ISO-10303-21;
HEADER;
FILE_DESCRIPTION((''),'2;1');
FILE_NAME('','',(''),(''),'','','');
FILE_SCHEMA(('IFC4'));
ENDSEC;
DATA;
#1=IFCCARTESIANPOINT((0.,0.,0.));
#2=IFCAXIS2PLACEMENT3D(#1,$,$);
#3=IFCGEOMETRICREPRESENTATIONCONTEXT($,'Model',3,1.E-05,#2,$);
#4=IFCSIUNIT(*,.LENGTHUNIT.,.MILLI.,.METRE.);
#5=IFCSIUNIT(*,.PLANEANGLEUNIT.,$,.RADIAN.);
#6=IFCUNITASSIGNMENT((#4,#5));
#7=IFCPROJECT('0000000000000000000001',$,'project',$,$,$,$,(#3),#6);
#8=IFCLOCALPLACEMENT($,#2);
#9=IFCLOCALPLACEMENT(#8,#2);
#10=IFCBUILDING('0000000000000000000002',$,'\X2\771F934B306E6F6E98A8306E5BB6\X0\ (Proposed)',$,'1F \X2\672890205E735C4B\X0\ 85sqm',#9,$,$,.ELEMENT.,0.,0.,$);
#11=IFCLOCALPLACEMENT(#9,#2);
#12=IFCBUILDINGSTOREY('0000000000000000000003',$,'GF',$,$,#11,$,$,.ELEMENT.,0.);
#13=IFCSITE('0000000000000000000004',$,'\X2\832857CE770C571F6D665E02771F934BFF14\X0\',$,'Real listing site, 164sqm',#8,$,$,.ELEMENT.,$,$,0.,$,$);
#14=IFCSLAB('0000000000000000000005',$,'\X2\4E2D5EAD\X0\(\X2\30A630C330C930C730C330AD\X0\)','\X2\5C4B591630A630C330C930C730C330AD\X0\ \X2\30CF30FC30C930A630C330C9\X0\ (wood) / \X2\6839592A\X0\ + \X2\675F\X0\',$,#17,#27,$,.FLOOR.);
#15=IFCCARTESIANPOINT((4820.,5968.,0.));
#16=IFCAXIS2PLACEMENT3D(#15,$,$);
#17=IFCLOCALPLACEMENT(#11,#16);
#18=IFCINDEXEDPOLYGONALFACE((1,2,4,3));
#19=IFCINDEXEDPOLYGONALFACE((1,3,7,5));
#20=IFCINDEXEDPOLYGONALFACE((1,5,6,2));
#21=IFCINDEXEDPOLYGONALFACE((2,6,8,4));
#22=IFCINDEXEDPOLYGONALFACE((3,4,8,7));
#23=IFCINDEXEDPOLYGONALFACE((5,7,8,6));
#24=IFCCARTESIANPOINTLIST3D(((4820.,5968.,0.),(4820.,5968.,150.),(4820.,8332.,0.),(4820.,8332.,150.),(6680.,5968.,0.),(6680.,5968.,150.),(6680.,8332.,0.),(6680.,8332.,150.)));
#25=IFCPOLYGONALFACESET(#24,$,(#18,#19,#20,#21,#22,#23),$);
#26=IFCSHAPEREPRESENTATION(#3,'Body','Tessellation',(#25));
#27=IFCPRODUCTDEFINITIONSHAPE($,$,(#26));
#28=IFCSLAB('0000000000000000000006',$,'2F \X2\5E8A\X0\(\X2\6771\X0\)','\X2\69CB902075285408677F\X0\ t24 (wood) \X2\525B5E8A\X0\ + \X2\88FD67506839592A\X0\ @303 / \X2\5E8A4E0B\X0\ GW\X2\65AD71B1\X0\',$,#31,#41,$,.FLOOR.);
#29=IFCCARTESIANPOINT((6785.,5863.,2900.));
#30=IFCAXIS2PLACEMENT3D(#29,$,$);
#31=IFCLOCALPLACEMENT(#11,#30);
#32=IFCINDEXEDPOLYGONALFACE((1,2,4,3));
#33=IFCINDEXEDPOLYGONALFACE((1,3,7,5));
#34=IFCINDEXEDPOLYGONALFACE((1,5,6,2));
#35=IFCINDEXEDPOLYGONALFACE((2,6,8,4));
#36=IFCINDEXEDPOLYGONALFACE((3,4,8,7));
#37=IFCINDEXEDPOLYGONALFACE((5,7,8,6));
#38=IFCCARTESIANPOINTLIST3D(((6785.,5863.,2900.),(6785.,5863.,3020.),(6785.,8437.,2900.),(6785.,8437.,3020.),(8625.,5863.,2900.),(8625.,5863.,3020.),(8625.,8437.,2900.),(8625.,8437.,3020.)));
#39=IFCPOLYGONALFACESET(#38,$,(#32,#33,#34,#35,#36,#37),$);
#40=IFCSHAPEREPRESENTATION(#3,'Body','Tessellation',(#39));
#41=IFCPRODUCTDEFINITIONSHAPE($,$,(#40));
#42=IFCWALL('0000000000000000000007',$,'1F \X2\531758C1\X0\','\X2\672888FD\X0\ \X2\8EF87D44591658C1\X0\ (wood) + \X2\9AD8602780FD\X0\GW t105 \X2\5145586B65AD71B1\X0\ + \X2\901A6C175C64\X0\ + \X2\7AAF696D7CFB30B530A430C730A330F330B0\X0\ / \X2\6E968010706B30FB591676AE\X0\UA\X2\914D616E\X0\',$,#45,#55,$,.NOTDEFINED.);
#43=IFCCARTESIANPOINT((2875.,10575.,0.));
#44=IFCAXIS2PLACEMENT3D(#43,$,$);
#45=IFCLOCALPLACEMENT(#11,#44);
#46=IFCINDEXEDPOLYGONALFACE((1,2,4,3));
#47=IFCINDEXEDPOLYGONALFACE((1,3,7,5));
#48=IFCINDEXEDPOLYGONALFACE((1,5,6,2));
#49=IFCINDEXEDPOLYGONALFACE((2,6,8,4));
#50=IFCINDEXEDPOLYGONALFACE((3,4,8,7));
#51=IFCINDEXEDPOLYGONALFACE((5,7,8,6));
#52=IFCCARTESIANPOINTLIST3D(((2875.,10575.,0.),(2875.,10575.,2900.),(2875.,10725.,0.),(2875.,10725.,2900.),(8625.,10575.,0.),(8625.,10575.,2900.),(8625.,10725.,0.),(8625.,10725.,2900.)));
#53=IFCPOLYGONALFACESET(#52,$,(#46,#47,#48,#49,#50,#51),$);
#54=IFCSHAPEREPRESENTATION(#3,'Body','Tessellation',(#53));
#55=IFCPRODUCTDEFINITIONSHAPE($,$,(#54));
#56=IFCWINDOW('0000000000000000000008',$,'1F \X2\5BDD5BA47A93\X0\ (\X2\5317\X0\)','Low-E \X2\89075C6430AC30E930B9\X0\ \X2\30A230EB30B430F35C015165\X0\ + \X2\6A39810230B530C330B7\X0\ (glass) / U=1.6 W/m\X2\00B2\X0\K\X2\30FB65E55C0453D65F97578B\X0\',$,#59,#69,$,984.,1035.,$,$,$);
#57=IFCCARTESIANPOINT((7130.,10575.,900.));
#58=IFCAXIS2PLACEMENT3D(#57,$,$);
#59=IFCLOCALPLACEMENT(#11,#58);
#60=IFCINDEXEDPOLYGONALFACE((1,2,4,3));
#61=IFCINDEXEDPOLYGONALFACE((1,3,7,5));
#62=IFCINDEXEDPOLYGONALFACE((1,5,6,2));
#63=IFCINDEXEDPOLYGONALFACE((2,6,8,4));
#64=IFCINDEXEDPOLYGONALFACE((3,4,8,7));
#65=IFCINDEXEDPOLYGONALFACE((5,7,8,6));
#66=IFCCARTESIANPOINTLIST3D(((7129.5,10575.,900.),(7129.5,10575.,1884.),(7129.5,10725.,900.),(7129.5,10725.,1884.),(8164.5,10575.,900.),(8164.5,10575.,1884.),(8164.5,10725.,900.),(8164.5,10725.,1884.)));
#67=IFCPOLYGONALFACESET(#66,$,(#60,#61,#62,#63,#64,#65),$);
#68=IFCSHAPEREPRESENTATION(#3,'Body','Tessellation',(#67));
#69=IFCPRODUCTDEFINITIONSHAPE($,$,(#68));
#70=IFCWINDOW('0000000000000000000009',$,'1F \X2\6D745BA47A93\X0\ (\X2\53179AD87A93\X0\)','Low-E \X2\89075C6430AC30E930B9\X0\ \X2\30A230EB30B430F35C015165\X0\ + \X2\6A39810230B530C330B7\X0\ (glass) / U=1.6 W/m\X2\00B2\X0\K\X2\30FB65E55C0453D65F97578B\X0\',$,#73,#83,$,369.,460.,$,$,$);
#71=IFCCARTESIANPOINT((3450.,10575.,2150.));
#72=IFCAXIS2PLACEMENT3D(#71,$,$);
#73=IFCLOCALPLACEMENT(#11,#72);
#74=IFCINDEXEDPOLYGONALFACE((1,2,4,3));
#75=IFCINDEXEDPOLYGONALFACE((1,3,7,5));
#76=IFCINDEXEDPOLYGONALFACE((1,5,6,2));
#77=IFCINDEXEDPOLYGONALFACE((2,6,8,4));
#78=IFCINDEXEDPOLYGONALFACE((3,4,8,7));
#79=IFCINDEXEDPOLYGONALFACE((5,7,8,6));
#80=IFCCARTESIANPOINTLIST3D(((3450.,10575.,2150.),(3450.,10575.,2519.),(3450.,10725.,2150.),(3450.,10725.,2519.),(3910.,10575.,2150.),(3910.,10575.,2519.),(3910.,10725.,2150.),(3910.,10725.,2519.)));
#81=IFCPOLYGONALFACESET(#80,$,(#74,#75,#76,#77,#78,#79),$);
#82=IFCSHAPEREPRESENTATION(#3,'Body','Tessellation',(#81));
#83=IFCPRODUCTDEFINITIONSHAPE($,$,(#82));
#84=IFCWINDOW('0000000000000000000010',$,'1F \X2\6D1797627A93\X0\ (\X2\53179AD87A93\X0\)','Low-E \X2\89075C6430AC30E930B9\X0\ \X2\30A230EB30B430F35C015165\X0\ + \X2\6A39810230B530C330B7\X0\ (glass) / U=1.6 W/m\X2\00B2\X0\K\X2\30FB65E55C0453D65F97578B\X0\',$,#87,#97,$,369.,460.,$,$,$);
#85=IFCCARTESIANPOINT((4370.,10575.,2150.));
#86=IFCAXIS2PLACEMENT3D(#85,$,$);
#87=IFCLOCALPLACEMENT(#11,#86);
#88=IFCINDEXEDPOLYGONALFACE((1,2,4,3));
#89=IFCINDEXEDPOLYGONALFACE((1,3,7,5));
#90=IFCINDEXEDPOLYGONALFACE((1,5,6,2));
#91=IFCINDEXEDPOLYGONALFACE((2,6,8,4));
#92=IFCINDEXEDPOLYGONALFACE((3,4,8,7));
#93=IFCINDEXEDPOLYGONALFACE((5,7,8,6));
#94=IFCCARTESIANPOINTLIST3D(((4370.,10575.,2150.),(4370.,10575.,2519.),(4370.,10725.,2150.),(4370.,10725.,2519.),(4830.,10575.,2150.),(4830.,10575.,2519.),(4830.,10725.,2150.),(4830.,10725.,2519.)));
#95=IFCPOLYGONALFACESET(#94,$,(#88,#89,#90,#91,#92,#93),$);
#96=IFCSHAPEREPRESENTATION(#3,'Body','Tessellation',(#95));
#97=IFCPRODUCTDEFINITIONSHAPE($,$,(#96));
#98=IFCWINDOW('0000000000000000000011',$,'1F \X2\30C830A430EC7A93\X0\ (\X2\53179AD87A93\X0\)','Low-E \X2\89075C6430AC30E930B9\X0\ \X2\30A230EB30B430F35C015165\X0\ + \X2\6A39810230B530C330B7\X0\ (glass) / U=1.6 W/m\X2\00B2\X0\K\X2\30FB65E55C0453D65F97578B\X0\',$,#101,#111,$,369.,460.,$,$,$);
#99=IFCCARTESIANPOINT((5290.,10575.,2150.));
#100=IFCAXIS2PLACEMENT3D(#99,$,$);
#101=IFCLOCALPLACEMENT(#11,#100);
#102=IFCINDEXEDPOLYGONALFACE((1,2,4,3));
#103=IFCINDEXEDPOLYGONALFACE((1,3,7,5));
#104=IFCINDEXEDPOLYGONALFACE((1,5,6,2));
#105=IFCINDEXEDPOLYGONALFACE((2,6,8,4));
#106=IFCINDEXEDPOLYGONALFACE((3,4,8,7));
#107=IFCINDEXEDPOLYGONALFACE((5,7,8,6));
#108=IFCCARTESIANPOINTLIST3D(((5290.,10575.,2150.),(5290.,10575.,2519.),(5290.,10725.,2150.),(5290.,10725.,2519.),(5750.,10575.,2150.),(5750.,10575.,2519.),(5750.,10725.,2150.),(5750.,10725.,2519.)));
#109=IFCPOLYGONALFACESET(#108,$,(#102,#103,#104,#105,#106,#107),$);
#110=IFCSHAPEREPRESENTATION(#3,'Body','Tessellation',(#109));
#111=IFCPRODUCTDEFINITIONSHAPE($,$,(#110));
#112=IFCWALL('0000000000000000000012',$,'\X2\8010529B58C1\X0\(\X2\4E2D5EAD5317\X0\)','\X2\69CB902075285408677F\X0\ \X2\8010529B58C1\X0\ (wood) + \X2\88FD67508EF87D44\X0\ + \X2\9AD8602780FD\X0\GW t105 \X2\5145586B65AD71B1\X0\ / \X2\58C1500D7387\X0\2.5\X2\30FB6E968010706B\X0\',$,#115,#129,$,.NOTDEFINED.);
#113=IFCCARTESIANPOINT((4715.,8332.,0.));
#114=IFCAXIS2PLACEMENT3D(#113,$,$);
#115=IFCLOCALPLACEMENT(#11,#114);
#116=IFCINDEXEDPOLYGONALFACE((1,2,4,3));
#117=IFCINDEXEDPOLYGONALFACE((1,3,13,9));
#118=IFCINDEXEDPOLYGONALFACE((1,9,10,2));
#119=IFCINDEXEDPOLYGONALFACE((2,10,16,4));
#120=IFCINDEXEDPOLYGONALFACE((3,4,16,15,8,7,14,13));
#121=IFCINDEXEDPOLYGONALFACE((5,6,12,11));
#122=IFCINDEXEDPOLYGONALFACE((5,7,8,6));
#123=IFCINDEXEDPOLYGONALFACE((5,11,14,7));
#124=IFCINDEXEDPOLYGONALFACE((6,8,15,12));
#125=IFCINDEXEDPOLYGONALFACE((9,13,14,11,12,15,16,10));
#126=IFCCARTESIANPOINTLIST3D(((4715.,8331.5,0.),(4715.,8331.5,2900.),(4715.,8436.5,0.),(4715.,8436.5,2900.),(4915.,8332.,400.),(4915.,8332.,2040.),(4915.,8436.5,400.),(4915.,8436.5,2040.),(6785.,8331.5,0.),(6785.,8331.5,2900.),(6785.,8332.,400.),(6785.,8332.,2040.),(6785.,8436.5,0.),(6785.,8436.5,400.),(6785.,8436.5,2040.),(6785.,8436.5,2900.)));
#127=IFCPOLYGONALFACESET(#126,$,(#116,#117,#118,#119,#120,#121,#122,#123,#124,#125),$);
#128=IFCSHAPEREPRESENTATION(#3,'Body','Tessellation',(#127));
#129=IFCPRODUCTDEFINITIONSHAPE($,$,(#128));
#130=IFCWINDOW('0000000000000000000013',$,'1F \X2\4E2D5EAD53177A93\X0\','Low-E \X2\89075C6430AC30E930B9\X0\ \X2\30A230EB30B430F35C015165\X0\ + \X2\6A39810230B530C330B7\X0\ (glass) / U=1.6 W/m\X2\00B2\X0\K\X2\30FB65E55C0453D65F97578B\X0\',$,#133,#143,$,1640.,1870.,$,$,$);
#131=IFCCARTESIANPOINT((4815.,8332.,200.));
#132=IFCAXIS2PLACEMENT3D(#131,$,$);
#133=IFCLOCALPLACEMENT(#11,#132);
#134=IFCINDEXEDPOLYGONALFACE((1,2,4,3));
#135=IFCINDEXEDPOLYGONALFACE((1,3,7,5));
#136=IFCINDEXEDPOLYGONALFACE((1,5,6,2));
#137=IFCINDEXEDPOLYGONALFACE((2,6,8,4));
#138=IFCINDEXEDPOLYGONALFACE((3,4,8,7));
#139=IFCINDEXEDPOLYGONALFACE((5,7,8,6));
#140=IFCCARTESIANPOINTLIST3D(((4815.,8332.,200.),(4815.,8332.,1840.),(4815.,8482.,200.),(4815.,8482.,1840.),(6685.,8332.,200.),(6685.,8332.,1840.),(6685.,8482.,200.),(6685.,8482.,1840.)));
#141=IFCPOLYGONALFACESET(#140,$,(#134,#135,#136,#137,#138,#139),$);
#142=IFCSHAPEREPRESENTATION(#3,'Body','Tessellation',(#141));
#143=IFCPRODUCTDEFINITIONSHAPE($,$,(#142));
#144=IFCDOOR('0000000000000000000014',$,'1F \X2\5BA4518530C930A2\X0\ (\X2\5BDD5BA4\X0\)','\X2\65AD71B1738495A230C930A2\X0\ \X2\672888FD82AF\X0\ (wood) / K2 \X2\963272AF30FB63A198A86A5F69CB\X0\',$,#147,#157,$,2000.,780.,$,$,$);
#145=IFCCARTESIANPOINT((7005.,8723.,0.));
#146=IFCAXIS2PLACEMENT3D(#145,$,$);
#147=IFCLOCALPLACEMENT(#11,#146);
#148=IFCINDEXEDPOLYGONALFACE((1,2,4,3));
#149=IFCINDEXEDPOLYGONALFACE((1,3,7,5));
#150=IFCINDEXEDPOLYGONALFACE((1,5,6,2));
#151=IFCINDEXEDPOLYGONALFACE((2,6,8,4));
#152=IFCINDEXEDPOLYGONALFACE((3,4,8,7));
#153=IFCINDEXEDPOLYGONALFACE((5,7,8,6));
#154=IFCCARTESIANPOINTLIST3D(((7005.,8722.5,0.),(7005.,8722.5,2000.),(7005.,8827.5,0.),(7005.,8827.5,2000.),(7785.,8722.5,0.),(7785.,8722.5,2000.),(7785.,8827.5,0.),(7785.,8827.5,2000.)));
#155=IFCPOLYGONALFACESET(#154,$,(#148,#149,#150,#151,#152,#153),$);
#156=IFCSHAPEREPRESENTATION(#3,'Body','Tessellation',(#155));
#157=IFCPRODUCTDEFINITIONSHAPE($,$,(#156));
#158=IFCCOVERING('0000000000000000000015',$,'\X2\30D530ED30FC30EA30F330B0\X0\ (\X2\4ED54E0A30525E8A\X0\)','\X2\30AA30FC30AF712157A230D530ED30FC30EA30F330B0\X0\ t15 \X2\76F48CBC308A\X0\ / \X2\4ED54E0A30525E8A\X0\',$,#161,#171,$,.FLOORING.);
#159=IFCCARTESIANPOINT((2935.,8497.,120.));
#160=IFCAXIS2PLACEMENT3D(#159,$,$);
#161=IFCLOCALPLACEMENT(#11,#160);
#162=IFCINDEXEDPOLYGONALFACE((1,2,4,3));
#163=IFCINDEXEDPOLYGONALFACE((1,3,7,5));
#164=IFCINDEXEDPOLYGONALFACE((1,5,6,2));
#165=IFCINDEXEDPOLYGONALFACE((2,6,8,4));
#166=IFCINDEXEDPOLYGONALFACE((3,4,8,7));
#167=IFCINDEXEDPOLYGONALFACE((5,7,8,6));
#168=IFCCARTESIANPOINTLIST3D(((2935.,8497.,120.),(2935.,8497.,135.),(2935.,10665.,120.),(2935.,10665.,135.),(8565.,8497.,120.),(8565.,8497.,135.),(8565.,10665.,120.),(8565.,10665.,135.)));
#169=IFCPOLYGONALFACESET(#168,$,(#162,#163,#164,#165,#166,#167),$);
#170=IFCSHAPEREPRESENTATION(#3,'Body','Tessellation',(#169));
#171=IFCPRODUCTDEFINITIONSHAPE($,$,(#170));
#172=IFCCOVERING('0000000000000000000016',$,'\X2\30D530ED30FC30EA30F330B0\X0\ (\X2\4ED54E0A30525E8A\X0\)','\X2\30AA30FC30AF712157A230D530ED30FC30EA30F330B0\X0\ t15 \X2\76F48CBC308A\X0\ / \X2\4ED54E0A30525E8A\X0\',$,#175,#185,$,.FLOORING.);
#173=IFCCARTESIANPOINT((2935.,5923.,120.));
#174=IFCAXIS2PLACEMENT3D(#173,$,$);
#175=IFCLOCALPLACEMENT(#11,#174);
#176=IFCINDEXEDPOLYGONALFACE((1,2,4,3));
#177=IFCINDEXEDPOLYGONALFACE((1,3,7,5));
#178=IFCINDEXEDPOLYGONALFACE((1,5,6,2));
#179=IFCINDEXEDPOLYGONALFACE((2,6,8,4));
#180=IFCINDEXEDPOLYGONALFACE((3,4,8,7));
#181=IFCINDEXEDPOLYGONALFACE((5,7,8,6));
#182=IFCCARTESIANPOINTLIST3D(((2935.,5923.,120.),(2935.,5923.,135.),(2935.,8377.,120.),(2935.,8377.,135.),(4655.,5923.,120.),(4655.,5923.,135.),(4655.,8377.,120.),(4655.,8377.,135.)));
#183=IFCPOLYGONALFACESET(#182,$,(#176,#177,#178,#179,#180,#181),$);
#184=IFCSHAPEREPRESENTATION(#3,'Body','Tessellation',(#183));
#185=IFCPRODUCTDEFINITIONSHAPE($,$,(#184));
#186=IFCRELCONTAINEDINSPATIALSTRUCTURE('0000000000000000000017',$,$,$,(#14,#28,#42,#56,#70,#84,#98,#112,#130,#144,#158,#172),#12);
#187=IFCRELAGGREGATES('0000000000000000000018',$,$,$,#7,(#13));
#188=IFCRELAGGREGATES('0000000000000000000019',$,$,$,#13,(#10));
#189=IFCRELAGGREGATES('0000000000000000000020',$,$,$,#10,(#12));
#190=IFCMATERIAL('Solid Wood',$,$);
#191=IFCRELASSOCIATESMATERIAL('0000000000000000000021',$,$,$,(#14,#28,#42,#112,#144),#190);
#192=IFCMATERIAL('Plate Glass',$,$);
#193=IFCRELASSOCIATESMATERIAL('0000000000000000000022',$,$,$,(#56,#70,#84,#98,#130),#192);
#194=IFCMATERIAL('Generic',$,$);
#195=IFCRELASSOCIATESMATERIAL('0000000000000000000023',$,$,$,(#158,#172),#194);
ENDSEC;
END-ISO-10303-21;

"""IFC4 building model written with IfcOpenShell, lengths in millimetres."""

from ifc_helpers import new_model, si_unit, frame, frame_2d, origin, place, context, project, spatial, rectangle, extrude, material, element, fill, save


model = new_model("IFC4")

# Units and contexts
model_context = context("Model", 3, precision=1e-05, world=origin())
ifc_project = project(units=[si_unit("LENGTHUNIT", "METRE", prefix="MILLI"), si_unit("PLANEANGLEUNIT", "RADIAN")], contexts=[model_context])

# Site, building, storey
site_placement = place(None, origin())
site = spatial("IfcSite", under=ifc_project, at=site_placement, Name="茨城県土浦市真鍋４", ObjectType="Real listing site, 164sqm", CompositionType="ELEMENT", RefElevation=0.0)
building_placement = place(site_placement, origin())
building = spatial("IfcBuilding", under=site, at=building_placement, Name="真鍋の潮風の家 (Proposed)", ObjectType="1F 木造平屋 85sqm", CompositionType="ELEMENT", ElevationOfRefHeight=0.0, ElevationOfTerrain=0.0)
storey_placement = place(building_placement, origin())
storey = spatial("IfcBuildingStorey", under=building, at=storey_placement, Name="GF", CompositionType="ELEMENT", Elevation=0.0)

# Slabs
ifc_material_1 = material(Name="Solid Wood")
slab_1_placement = place(storey_placement, frame((4820.0, 5968.0, 0.0)))
element("IfcSlab", 1, at=slab_1_placement, inside=storey, material=ifc_material_1, Name="中庭(ウッドデッキ)", Description="屋外ウッドデッキ ハードウッド (wood) / 根太 + 束", PredefinedType="FLOOR", context=model_context, shape_type="SweptSolid", body=[
    extrude(rectangle(XDim=1860.0, YDim=2364.0, at=frame_2d((930.0, 1182.0))), frame((4820.0, 5968.0, 0.0)), (0.0, 0.0, 1.0), 150.0),
])
slab_2_placement = place(storey_placement, frame((6785.0, 5863.0, 2900.0)))
element("IfcSlab", 2, at=slab_2_placement, inside=storey, material=ifc_material_1, Name="2F 床(東)", Description="構造用合板 t24 (wood) 剛床 + 製材根太 @303 / 床下 GW断熱", PredefinedType="FLOOR", context=model_context, shape_type="SweptSolid", body=[
    extrude(rectangle(XDim=1840.0, YDim=2574.0, at=frame_2d((920.0, 1287.0))), frame((6785.0, 5863.0, 2900.0)), (0.0, 0.0, 1.0), 120.0),
])

# Wall, openings, windows
wall_1_placement = place(storey_placement, frame((2875.0, 10575.0, 0.0)))
wall_1 = element("IfcWall", 3, at=wall_1_placement, inside=storey, material=ifc_material_1, Name="1F 北壁", Description="木製 軸組外壁 (wood) + 高性能GW t105 充填断熱 + 通気層 + 窯業系サイディング / 準耐火・外皮UA配慮", PredefinedType="NOTDEFINED", context=model_context, shape_type="SweptSolid", body=[
    extrude(rectangle(XDim=5750.0, YDim=150.0, at=frame_2d((2875.0, 75.0))), frame((2875.0, 10575.0, 0.0)), (0.0, 0.0, 1.0), 2900.0),
])
opening_1_placement = place(storey_placement, frame((7130.0, 10575.0, 900.0)))
opening_1 = element("IfcOpeningElement", 4, at=opening_1_placement, cuts=wall_1, PredefinedType="NOTDEFINED", context=model_context, shape_type="SweptSolid", body=[
    extrude(rectangle(XDim=1035.0, YDim=150.0, at=frame_2d((517.0, 75.0))), frame((7130.0, 10575.0, 900.0)), (0.0, 0.0, 1.0), 984.0),
])
opening_2_placement = place(storey_placement, frame((3450.0, 10575.0, 2150.0)))
opening_2 = element("IfcOpeningElement", 5, at=opening_2_placement, cuts=wall_1, PredefinedType="NOTDEFINED", context=model_context, shape_type="SweptSolid", body=[
    extrude(rectangle(XDim=460.0, YDim=150.0, at=frame_2d((230.0, 75.0))), frame((3450.0, 10575.0, 2150.0)), (0.0, 0.0, 1.0), 369.0),
])
opening_3_placement = place(storey_placement, frame((4370.0, 10575.0, 2150.0)))
opening_3 = element("IfcOpeningElement", 6, at=opening_3_placement, cuts=wall_1, PredefinedType="NOTDEFINED", context=model_context, shape_type="SweptSolid", body=[
    extrude(rectangle(XDim=460.0, YDim=150.0, at=frame_2d((230.0, 75.0))), frame((4370.0, 10575.0, 2150.0)), (0.0, 0.0, 1.0), 369.0),
])
opening_4_placement = place(storey_placement, frame((5290.0, 10575.0, 2150.0)))
opening_4 = element("IfcOpeningElement", 7, at=opening_4_placement, cuts=wall_1, PredefinedType="NOTDEFINED", context=model_context, shape_type="SweptSolid", body=[
    extrude(rectangle(XDim=460.0, YDim=150.0, at=frame_2d((230.0, 75.0))), frame((5290.0, 10575.0, 2150.0)), (0.0, 0.0, 1.0), 369.0),
])
ifc_material_2 = material(Name="Plate Glass")
window_1_placement = place(storey_placement, frame((7130.0, 10575.0, 900.0)))
window_1 = element("IfcWindow", 8, at=window_1_placement, inside=storey, material=ifc_material_2, Name="1F 寝室窓 (北)", Description="Low-E 複層ガラス アルゴン封入 + 樹脂サッシ (glass) / U=1.6 W/m²K・日射取得型", OverallHeight=984.0, OverallWidth=1035.0, context=model_context, shape_type="SweptSolid", body=[
    extrude(rectangle(XDim=1035.0, YDim=150.0, at=frame_2d((517.0, 75.0))), frame((7130.0, 10575.0, 900.0)), (0.0, 0.0, 1.0), 984.0),
])
fill(opening_1, window_1)
window_2_placement = place(storey_placement, frame((3450.0, 10575.0, 2150.0)))
window_2 = element("IfcWindow", 9, at=window_2_placement, inside=storey, material=ifc_material_2, Name="1F 浴室窓 (北高窓)", Description="Low-E 複層ガラス アルゴン封入 + 樹脂サッシ (glass) / U=1.6 W/m²K・日射取得型", OverallHeight=369.0, OverallWidth=460.0, context=model_context, shape_type="SweptSolid", body=[
    extrude(rectangle(XDim=460.0, YDim=150.0, at=frame_2d((230.0, 75.0))), frame((3450.0, 10575.0, 2150.0)), (0.0, 0.0, 1.0), 369.0),
])
fill(opening_2, window_2)
window_3_placement = place(storey_placement, frame((4370.0, 10575.0, 2150.0)))
window_3 = element("IfcWindow", 10, at=window_3_placement, inside=storey, material=ifc_material_2, Name="1F 洗面窓 (北高窓)", Description="Low-E 複層ガラス アルゴン封入 + 樹脂サッシ (glass) / U=1.6 W/m²K・日射取得型", OverallHeight=369.0, OverallWidth=460.0, context=model_context, shape_type="SweptSolid", body=[
    extrude(rectangle(XDim=460.0, YDim=150.0, at=frame_2d((230.0, 75.0))), frame((4370.0, 10575.0, 2150.0)), (0.0, 0.0, 1.0), 369.0),
])
fill(opening_3, window_3)
window_4_placement = place(storey_placement, frame((5290.0, 10575.0, 2150.0)))
window_4 = element("IfcWindow", 11, at=window_4_placement, inside=storey, material=ifc_material_2, Name="1F トイレ窓 (北高窓)", Description="Low-E 複層ガラス アルゴン封入 + 樹脂サッシ (glass) / U=1.6 W/m²K・日射取得型", OverallHeight=369.0, OverallWidth=460.0, context=model_context, shape_type="SweptSolid", body=[
    extrude(rectangle(XDim=460.0, YDim=150.0, at=frame_2d((230.0, 75.0))), frame((5290.0, 10575.0, 2150.0)), (0.0, 0.0, 1.0), 369.0),
])
fill(opening_4, window_4)

# Wall, opening, window
wall_2_placement = place(storey_placement, frame((4715.0, 8332.0, 0.0)))
wall_2 = element("IfcWall", 12, at=wall_2_placement, inside=storey, material=ifc_material_1, Name="耐力壁(中庭北)", Description="構造用合板 耐力壁 (wood) + 製材軸組 + 高性能GW t105 充填断熱 / 壁倍率2.5・準耐火", PredefinedType="NOTDEFINED", context=model_context, shape_type="SweptSolid", body=[
    extrude(rectangle(XDim=2070.0, YDim=105.0, at=frame_2d((1035.0, 52.0))), frame((4715.0, 8332.0, 0.0)), (0.0, 0.0, 1.0), 2900.0),
])
opening_5_placement = place(storey_placement, frame((4815.0, 8332.0, 200.0)))
opening_5 = element("IfcOpeningElement", 13, at=opening_5_placement, cuts=wall_2, PredefinedType="NOTDEFINED", context=model_context, shape_type="SweptSolid", body=[
    extrude(rectangle(XDim=1870.0, YDim=150.0, at=frame_2d((935.0, 75.0))), frame((4815.0, 8332.0, 200.0)), (0.0, 0.0, 1.0), 1640.0),
])
window_5_placement = place(storey_placement, frame((4815.0, 8332.0, 200.0)))
window_5 = element("IfcWindow", 14, at=window_5_placement, inside=storey, material=ifc_material_2, Name="1F 中庭北窓", Description="Low-E 複層ガラス アルゴン封入 + 樹脂サッシ (glass) / U=1.6 W/m²K・日射取得型", OverallHeight=1640.0, OverallWidth=1870.0, context=model_context, shape_type="SweptSolid", body=[
    extrude(rectangle(XDim=1870.0, YDim=150.0, at=frame_2d((935.0, 75.0))), frame((4815.0, 8332.0, 200.0)), (0.0, 0.0, 1.0), 1640.0),
])
fill(opening_5, window_5)

# Door
door_1_placement = place(storey_placement, frame((7005.0, 8723.0, 0.0)))
element("IfcDoor", 15, at=door_1_placement, inside=storey, material=ifc_material_1, Name="1F 室内ドア (寝室)", Description="断熱玄関ドア 木製芯 (wood) / K2 防犯・採風機構", OverallHeight=2000.0, OverallWidth=780.0, context=model_context, shape_type="SweptSolid", body=[
    extrude(rectangle(XDim=780.0, YDim=105.0, at=frame_2d((390.0, 52.0))), frame((7005.0, 8723.0, 0.0)), (0.0, 0.0, 1.0), 2000.0),
])

# Coverings
ifc_material_3 = material(Name="Generic")
covering_1_placement = place(storey_placement, frame((2935.0, 8497.0, 120.0)))
element("IfcCovering", 16, at=covering_1_placement, inside=storey, material=ifc_material_3, Name="フローリング (仕上げ床)", Description="オーク無垢フローリング t15 直貼り / 仕上げ床", PredefinedType="FLOORING", context=model_context, shape_type="SweptSolid", body=[
    extrude(rectangle(XDim=5630.0, YDim=2168.0, at=frame_2d((2815.0, 1084.0))), frame((2935.0, 8497.0, 120.0)), (0.0, 0.0, 1.0), 15.0),
])
covering_2_placement = place(storey_placement, frame((2935.0, 5923.0, 120.0)))
element("IfcCovering", 17, at=covering_2_placement, inside=storey, material=ifc_material_3, Name="フローリング (仕上げ床)", Description="オーク無垢フローリング t15 直貼り / 仕上げ床", PredefinedType="FLOORING", context=model_context, shape_type="SweptSolid", body=[
    extrude(rectangle(XDim=1720.0, YDim=2454.0, at=frame_2d((860.0, 1227.0))), frame((2935.0, 5923.0, 120.0)), (0.0, 0.0, 1.0), 15.0),
])

save(model, "model.ifc")
